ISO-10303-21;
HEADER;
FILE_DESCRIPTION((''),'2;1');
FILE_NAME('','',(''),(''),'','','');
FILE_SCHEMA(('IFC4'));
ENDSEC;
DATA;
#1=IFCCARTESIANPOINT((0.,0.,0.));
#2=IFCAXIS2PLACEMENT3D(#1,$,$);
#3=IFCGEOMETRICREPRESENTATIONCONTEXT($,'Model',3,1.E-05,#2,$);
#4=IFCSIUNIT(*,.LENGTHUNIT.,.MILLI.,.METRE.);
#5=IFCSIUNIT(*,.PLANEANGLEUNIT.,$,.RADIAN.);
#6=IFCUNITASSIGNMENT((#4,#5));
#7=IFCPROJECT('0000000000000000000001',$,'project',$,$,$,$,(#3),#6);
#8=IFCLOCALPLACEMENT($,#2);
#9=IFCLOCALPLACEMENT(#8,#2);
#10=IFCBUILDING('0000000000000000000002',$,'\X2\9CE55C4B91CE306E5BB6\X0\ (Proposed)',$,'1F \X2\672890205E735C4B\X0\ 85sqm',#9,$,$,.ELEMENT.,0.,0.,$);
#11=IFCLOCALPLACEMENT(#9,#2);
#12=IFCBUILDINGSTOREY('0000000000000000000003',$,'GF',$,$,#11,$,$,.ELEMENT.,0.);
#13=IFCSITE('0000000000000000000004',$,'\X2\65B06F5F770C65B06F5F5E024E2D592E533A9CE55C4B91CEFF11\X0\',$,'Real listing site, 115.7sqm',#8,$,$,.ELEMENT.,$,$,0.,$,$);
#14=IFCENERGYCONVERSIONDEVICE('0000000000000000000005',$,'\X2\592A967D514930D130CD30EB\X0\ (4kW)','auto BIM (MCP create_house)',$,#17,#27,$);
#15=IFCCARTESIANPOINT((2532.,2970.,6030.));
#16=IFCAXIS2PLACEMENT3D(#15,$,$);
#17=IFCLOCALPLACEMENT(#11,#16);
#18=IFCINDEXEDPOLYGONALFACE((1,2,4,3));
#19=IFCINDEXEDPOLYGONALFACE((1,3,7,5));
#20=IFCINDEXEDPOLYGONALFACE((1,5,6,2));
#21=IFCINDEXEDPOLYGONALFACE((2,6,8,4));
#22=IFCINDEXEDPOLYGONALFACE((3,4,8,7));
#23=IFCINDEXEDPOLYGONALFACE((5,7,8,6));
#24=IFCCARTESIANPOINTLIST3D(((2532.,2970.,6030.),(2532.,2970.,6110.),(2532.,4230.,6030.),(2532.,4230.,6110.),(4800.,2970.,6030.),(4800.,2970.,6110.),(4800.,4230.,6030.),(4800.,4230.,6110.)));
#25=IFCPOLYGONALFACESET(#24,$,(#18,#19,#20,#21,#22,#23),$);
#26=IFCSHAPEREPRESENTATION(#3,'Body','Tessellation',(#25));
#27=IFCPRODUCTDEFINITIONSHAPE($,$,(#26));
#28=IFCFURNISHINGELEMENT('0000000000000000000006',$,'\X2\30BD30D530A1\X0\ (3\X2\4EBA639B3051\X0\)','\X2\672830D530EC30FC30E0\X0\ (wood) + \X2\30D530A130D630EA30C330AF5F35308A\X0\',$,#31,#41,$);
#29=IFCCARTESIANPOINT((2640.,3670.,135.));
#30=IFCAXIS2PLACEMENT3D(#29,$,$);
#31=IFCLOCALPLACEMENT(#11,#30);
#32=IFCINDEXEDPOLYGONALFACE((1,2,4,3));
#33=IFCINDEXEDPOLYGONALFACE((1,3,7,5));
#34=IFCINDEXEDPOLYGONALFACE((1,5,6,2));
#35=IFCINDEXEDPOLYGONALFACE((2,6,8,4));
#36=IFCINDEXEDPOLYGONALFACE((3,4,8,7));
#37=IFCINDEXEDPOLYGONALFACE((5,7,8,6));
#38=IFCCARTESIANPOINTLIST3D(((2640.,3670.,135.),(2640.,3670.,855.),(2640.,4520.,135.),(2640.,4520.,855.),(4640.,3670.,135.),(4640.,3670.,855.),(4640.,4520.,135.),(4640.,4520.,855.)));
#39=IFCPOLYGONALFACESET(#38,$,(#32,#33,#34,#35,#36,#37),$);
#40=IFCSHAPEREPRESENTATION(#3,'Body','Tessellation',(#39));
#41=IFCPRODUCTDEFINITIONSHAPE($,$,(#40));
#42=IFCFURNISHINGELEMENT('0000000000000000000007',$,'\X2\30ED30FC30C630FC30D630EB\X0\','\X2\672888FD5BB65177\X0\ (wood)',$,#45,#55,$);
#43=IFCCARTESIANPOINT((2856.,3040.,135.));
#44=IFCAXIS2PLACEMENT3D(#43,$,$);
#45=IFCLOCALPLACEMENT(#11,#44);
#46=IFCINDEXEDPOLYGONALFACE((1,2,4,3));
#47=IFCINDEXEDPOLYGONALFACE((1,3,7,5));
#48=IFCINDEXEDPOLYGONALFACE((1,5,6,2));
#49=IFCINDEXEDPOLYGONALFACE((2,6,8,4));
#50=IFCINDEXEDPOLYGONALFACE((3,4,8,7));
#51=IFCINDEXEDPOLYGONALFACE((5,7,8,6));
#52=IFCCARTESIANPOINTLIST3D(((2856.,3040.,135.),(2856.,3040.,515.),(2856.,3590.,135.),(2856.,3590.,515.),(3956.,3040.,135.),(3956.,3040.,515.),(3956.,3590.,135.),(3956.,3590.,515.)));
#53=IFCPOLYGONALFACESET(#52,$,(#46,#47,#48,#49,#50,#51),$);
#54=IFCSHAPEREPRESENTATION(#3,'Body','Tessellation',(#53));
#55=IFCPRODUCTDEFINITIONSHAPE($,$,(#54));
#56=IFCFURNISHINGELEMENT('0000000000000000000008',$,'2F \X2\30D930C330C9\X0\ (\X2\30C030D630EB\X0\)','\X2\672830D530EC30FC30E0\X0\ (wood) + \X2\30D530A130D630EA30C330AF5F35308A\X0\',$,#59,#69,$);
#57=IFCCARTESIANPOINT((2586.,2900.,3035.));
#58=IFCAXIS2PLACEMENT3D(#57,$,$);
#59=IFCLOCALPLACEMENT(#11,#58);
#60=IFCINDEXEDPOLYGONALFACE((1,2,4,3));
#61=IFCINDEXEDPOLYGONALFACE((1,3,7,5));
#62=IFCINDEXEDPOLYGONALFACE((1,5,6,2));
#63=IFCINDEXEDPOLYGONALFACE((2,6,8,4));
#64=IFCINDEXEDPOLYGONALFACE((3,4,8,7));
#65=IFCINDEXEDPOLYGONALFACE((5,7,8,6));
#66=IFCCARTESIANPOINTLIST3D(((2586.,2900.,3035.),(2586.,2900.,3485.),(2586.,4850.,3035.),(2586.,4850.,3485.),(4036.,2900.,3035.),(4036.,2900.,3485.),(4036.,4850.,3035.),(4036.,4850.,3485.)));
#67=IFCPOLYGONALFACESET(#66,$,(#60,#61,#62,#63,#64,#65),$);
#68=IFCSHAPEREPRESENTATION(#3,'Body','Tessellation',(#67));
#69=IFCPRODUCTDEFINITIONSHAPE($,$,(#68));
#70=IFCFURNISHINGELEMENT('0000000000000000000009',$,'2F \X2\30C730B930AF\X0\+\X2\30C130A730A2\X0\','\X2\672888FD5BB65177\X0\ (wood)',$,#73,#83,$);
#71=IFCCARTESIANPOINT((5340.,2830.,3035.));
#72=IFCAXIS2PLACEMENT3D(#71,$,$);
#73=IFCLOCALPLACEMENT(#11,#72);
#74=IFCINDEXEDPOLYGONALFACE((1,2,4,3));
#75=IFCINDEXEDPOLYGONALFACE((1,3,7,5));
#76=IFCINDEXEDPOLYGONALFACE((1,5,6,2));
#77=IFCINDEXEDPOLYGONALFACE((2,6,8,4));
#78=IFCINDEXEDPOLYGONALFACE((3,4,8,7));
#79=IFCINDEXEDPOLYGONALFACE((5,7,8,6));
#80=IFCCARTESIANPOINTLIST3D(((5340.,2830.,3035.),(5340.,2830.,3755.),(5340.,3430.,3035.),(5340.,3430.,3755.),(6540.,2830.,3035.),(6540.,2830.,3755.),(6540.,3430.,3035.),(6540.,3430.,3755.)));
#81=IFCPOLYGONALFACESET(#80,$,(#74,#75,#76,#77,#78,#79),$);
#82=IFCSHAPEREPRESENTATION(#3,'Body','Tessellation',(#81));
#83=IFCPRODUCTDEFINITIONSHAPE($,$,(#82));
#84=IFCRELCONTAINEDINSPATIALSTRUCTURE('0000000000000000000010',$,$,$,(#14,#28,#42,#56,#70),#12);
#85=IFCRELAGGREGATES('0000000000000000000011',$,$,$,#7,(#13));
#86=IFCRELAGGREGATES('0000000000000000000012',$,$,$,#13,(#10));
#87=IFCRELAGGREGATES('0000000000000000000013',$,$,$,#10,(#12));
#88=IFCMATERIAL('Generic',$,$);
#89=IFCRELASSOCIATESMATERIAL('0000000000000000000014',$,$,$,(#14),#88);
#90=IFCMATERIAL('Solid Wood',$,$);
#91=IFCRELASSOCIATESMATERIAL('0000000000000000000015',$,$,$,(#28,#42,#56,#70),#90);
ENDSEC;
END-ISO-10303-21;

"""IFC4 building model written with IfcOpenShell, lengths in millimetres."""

from ifc_helpers import new_model, si_unit, frame, frame_2d, origin, place, context, project, spatial, rectangle, extrude, material, element, save


model = new_model("IFC4")

# Units and contexts
model_context = context("Model", 3, precision=1e-05, world=origin())
ifc_project = project(units=[si_unit("LENGTHUNIT", "METRE", prefix="MILLI"), si_unit("PLANEANGLEUNIT", "RADIAN")], contexts=[model_context])

# Site, building, storey
site_placement = place(None, origin())
site = spatial("IfcSite", under=ifc_project, at=site_placement, Name="新潟県新潟市中央区鳥屋野１", ObjectType="Real listing site, 115.7sqm", CompositionType="ELEMENT", RefElevation=0.0)
building_placement = place(site_placement, origin())
building = spatial("IfcBuilding", under=site, at=building_placement, Name="鳥屋野の家 (Proposed)", ObjectType="1F 木造平屋 85sqm", CompositionType="ELEMENT", ElevationOfRefHeight=0.0, ElevationOfTerrain=0.0)
storey_placement = place(building_placement, origin())
storey = spatial("IfcBuildingStorey", under=building, at=storey_placement, Name="GF", CompositionType="ELEMENT", Elevation=0.0)

# Shared definitions
ifc_material_1 = material(Name="Solid Wood")

# Shared definitions
ifc_material_2 = material(Name="Generic")

# Energy conversion device
energy_conversion_device_placement = place(storey_placement, frame((2532.0, 2970.0, 6030.0)))
element("IfcEnergyConversionDevice", 1, at=energy_conversion_device_placement, inside=storey, material=ifc_material_2, Name="太陽光パネル (4kW)", Description="auto BIM (MCP create_house)", context=model_context, shape_type="SweptSolid", body=[
    extrude(rectangle(XDim=2268.0, YDim=1260.0, at=frame_2d((1134.0, 630.0))), frame((2532.0, 2970.0, 6030.0)), (0.0, 0.0, 1.0), 80.0),
])

# Furnishing elements
furnishing_1_placement = place(storey_placement, frame((2640.0, 3670.0, 135.0)))
element("IfcFurnishingElement", 2, at=furnishing_1_placement, inside=storey, material=ifc_material_1, Name="ソファ (3人掛け)", Description="木フレーム (wood) + ファブリック張り", context=model_context, shape_type="SweptSolid", body=[
    extrude(rectangle(XDim=2000.0, YDim=850.0, at=frame_2d((1000.0, 425.0))), frame((2640.0, 3670.0, 135.0)), (0.0, 0.0, 1.0), 720.0),
])
furnishing_2_placement = place(storey_placement, frame((2856.0, 3040.0, 135.0)))
element("IfcFurnishingElement", 3, at=furnishing_2_placement, inside=storey, material=ifc_material_1, Name="ローテーブル", Description="木製家具 (wood)", context=model_context, shape_type="SweptSolid", body=[
    extrude(rectangle(XDim=1100.0, YDim=550.0, at=frame_2d((550.0, 275.0))), frame((2856.0, 3040.0, 135.0)), (0.0, 0.0, 1.0), 380.0),
])
furnishing_3_placement = place(storey_placement, frame((2586.0, 2900.0, 3035.0)))
element("IfcFurnishingElement", 4, at=furnishing_3_placement, inside=storey, material=ifc_material_1, Name="2F ベッド (ダブル)", Description="木フレーム (wood) + ファブリック張り", context=model_context, shape_type="SweptSolid", body=[
    extrude(rectangle(XDim=1450.0, YDim=1950.0, at=frame_2d((725.0, 975.0))), frame((2586.0, 2900.0, 3035.0)), (0.0, 0.0, 1.0), 450.0),
])
furnishing_4_placement = place(storey_placement, frame((5340.0, 2830.0, 3035.0)))
element("IfcFurnishingElement", 5, at=furnishing_4_placement, inside=storey, material=ifc_material_1, Name="2F デスク+チェア", Description="木製家具 (wood)", context=model_context, shape_type="SweptSolid", body=[
    extrude(rectangle(XDim=1200.0, YDim=600.0, at=frame_2d((600.0, 300.0))), frame((5340.0, 2830.0, 3035.0)), (0.0, 0.0, 1.0), 720.0),
])

save(model, "model.ifc")
